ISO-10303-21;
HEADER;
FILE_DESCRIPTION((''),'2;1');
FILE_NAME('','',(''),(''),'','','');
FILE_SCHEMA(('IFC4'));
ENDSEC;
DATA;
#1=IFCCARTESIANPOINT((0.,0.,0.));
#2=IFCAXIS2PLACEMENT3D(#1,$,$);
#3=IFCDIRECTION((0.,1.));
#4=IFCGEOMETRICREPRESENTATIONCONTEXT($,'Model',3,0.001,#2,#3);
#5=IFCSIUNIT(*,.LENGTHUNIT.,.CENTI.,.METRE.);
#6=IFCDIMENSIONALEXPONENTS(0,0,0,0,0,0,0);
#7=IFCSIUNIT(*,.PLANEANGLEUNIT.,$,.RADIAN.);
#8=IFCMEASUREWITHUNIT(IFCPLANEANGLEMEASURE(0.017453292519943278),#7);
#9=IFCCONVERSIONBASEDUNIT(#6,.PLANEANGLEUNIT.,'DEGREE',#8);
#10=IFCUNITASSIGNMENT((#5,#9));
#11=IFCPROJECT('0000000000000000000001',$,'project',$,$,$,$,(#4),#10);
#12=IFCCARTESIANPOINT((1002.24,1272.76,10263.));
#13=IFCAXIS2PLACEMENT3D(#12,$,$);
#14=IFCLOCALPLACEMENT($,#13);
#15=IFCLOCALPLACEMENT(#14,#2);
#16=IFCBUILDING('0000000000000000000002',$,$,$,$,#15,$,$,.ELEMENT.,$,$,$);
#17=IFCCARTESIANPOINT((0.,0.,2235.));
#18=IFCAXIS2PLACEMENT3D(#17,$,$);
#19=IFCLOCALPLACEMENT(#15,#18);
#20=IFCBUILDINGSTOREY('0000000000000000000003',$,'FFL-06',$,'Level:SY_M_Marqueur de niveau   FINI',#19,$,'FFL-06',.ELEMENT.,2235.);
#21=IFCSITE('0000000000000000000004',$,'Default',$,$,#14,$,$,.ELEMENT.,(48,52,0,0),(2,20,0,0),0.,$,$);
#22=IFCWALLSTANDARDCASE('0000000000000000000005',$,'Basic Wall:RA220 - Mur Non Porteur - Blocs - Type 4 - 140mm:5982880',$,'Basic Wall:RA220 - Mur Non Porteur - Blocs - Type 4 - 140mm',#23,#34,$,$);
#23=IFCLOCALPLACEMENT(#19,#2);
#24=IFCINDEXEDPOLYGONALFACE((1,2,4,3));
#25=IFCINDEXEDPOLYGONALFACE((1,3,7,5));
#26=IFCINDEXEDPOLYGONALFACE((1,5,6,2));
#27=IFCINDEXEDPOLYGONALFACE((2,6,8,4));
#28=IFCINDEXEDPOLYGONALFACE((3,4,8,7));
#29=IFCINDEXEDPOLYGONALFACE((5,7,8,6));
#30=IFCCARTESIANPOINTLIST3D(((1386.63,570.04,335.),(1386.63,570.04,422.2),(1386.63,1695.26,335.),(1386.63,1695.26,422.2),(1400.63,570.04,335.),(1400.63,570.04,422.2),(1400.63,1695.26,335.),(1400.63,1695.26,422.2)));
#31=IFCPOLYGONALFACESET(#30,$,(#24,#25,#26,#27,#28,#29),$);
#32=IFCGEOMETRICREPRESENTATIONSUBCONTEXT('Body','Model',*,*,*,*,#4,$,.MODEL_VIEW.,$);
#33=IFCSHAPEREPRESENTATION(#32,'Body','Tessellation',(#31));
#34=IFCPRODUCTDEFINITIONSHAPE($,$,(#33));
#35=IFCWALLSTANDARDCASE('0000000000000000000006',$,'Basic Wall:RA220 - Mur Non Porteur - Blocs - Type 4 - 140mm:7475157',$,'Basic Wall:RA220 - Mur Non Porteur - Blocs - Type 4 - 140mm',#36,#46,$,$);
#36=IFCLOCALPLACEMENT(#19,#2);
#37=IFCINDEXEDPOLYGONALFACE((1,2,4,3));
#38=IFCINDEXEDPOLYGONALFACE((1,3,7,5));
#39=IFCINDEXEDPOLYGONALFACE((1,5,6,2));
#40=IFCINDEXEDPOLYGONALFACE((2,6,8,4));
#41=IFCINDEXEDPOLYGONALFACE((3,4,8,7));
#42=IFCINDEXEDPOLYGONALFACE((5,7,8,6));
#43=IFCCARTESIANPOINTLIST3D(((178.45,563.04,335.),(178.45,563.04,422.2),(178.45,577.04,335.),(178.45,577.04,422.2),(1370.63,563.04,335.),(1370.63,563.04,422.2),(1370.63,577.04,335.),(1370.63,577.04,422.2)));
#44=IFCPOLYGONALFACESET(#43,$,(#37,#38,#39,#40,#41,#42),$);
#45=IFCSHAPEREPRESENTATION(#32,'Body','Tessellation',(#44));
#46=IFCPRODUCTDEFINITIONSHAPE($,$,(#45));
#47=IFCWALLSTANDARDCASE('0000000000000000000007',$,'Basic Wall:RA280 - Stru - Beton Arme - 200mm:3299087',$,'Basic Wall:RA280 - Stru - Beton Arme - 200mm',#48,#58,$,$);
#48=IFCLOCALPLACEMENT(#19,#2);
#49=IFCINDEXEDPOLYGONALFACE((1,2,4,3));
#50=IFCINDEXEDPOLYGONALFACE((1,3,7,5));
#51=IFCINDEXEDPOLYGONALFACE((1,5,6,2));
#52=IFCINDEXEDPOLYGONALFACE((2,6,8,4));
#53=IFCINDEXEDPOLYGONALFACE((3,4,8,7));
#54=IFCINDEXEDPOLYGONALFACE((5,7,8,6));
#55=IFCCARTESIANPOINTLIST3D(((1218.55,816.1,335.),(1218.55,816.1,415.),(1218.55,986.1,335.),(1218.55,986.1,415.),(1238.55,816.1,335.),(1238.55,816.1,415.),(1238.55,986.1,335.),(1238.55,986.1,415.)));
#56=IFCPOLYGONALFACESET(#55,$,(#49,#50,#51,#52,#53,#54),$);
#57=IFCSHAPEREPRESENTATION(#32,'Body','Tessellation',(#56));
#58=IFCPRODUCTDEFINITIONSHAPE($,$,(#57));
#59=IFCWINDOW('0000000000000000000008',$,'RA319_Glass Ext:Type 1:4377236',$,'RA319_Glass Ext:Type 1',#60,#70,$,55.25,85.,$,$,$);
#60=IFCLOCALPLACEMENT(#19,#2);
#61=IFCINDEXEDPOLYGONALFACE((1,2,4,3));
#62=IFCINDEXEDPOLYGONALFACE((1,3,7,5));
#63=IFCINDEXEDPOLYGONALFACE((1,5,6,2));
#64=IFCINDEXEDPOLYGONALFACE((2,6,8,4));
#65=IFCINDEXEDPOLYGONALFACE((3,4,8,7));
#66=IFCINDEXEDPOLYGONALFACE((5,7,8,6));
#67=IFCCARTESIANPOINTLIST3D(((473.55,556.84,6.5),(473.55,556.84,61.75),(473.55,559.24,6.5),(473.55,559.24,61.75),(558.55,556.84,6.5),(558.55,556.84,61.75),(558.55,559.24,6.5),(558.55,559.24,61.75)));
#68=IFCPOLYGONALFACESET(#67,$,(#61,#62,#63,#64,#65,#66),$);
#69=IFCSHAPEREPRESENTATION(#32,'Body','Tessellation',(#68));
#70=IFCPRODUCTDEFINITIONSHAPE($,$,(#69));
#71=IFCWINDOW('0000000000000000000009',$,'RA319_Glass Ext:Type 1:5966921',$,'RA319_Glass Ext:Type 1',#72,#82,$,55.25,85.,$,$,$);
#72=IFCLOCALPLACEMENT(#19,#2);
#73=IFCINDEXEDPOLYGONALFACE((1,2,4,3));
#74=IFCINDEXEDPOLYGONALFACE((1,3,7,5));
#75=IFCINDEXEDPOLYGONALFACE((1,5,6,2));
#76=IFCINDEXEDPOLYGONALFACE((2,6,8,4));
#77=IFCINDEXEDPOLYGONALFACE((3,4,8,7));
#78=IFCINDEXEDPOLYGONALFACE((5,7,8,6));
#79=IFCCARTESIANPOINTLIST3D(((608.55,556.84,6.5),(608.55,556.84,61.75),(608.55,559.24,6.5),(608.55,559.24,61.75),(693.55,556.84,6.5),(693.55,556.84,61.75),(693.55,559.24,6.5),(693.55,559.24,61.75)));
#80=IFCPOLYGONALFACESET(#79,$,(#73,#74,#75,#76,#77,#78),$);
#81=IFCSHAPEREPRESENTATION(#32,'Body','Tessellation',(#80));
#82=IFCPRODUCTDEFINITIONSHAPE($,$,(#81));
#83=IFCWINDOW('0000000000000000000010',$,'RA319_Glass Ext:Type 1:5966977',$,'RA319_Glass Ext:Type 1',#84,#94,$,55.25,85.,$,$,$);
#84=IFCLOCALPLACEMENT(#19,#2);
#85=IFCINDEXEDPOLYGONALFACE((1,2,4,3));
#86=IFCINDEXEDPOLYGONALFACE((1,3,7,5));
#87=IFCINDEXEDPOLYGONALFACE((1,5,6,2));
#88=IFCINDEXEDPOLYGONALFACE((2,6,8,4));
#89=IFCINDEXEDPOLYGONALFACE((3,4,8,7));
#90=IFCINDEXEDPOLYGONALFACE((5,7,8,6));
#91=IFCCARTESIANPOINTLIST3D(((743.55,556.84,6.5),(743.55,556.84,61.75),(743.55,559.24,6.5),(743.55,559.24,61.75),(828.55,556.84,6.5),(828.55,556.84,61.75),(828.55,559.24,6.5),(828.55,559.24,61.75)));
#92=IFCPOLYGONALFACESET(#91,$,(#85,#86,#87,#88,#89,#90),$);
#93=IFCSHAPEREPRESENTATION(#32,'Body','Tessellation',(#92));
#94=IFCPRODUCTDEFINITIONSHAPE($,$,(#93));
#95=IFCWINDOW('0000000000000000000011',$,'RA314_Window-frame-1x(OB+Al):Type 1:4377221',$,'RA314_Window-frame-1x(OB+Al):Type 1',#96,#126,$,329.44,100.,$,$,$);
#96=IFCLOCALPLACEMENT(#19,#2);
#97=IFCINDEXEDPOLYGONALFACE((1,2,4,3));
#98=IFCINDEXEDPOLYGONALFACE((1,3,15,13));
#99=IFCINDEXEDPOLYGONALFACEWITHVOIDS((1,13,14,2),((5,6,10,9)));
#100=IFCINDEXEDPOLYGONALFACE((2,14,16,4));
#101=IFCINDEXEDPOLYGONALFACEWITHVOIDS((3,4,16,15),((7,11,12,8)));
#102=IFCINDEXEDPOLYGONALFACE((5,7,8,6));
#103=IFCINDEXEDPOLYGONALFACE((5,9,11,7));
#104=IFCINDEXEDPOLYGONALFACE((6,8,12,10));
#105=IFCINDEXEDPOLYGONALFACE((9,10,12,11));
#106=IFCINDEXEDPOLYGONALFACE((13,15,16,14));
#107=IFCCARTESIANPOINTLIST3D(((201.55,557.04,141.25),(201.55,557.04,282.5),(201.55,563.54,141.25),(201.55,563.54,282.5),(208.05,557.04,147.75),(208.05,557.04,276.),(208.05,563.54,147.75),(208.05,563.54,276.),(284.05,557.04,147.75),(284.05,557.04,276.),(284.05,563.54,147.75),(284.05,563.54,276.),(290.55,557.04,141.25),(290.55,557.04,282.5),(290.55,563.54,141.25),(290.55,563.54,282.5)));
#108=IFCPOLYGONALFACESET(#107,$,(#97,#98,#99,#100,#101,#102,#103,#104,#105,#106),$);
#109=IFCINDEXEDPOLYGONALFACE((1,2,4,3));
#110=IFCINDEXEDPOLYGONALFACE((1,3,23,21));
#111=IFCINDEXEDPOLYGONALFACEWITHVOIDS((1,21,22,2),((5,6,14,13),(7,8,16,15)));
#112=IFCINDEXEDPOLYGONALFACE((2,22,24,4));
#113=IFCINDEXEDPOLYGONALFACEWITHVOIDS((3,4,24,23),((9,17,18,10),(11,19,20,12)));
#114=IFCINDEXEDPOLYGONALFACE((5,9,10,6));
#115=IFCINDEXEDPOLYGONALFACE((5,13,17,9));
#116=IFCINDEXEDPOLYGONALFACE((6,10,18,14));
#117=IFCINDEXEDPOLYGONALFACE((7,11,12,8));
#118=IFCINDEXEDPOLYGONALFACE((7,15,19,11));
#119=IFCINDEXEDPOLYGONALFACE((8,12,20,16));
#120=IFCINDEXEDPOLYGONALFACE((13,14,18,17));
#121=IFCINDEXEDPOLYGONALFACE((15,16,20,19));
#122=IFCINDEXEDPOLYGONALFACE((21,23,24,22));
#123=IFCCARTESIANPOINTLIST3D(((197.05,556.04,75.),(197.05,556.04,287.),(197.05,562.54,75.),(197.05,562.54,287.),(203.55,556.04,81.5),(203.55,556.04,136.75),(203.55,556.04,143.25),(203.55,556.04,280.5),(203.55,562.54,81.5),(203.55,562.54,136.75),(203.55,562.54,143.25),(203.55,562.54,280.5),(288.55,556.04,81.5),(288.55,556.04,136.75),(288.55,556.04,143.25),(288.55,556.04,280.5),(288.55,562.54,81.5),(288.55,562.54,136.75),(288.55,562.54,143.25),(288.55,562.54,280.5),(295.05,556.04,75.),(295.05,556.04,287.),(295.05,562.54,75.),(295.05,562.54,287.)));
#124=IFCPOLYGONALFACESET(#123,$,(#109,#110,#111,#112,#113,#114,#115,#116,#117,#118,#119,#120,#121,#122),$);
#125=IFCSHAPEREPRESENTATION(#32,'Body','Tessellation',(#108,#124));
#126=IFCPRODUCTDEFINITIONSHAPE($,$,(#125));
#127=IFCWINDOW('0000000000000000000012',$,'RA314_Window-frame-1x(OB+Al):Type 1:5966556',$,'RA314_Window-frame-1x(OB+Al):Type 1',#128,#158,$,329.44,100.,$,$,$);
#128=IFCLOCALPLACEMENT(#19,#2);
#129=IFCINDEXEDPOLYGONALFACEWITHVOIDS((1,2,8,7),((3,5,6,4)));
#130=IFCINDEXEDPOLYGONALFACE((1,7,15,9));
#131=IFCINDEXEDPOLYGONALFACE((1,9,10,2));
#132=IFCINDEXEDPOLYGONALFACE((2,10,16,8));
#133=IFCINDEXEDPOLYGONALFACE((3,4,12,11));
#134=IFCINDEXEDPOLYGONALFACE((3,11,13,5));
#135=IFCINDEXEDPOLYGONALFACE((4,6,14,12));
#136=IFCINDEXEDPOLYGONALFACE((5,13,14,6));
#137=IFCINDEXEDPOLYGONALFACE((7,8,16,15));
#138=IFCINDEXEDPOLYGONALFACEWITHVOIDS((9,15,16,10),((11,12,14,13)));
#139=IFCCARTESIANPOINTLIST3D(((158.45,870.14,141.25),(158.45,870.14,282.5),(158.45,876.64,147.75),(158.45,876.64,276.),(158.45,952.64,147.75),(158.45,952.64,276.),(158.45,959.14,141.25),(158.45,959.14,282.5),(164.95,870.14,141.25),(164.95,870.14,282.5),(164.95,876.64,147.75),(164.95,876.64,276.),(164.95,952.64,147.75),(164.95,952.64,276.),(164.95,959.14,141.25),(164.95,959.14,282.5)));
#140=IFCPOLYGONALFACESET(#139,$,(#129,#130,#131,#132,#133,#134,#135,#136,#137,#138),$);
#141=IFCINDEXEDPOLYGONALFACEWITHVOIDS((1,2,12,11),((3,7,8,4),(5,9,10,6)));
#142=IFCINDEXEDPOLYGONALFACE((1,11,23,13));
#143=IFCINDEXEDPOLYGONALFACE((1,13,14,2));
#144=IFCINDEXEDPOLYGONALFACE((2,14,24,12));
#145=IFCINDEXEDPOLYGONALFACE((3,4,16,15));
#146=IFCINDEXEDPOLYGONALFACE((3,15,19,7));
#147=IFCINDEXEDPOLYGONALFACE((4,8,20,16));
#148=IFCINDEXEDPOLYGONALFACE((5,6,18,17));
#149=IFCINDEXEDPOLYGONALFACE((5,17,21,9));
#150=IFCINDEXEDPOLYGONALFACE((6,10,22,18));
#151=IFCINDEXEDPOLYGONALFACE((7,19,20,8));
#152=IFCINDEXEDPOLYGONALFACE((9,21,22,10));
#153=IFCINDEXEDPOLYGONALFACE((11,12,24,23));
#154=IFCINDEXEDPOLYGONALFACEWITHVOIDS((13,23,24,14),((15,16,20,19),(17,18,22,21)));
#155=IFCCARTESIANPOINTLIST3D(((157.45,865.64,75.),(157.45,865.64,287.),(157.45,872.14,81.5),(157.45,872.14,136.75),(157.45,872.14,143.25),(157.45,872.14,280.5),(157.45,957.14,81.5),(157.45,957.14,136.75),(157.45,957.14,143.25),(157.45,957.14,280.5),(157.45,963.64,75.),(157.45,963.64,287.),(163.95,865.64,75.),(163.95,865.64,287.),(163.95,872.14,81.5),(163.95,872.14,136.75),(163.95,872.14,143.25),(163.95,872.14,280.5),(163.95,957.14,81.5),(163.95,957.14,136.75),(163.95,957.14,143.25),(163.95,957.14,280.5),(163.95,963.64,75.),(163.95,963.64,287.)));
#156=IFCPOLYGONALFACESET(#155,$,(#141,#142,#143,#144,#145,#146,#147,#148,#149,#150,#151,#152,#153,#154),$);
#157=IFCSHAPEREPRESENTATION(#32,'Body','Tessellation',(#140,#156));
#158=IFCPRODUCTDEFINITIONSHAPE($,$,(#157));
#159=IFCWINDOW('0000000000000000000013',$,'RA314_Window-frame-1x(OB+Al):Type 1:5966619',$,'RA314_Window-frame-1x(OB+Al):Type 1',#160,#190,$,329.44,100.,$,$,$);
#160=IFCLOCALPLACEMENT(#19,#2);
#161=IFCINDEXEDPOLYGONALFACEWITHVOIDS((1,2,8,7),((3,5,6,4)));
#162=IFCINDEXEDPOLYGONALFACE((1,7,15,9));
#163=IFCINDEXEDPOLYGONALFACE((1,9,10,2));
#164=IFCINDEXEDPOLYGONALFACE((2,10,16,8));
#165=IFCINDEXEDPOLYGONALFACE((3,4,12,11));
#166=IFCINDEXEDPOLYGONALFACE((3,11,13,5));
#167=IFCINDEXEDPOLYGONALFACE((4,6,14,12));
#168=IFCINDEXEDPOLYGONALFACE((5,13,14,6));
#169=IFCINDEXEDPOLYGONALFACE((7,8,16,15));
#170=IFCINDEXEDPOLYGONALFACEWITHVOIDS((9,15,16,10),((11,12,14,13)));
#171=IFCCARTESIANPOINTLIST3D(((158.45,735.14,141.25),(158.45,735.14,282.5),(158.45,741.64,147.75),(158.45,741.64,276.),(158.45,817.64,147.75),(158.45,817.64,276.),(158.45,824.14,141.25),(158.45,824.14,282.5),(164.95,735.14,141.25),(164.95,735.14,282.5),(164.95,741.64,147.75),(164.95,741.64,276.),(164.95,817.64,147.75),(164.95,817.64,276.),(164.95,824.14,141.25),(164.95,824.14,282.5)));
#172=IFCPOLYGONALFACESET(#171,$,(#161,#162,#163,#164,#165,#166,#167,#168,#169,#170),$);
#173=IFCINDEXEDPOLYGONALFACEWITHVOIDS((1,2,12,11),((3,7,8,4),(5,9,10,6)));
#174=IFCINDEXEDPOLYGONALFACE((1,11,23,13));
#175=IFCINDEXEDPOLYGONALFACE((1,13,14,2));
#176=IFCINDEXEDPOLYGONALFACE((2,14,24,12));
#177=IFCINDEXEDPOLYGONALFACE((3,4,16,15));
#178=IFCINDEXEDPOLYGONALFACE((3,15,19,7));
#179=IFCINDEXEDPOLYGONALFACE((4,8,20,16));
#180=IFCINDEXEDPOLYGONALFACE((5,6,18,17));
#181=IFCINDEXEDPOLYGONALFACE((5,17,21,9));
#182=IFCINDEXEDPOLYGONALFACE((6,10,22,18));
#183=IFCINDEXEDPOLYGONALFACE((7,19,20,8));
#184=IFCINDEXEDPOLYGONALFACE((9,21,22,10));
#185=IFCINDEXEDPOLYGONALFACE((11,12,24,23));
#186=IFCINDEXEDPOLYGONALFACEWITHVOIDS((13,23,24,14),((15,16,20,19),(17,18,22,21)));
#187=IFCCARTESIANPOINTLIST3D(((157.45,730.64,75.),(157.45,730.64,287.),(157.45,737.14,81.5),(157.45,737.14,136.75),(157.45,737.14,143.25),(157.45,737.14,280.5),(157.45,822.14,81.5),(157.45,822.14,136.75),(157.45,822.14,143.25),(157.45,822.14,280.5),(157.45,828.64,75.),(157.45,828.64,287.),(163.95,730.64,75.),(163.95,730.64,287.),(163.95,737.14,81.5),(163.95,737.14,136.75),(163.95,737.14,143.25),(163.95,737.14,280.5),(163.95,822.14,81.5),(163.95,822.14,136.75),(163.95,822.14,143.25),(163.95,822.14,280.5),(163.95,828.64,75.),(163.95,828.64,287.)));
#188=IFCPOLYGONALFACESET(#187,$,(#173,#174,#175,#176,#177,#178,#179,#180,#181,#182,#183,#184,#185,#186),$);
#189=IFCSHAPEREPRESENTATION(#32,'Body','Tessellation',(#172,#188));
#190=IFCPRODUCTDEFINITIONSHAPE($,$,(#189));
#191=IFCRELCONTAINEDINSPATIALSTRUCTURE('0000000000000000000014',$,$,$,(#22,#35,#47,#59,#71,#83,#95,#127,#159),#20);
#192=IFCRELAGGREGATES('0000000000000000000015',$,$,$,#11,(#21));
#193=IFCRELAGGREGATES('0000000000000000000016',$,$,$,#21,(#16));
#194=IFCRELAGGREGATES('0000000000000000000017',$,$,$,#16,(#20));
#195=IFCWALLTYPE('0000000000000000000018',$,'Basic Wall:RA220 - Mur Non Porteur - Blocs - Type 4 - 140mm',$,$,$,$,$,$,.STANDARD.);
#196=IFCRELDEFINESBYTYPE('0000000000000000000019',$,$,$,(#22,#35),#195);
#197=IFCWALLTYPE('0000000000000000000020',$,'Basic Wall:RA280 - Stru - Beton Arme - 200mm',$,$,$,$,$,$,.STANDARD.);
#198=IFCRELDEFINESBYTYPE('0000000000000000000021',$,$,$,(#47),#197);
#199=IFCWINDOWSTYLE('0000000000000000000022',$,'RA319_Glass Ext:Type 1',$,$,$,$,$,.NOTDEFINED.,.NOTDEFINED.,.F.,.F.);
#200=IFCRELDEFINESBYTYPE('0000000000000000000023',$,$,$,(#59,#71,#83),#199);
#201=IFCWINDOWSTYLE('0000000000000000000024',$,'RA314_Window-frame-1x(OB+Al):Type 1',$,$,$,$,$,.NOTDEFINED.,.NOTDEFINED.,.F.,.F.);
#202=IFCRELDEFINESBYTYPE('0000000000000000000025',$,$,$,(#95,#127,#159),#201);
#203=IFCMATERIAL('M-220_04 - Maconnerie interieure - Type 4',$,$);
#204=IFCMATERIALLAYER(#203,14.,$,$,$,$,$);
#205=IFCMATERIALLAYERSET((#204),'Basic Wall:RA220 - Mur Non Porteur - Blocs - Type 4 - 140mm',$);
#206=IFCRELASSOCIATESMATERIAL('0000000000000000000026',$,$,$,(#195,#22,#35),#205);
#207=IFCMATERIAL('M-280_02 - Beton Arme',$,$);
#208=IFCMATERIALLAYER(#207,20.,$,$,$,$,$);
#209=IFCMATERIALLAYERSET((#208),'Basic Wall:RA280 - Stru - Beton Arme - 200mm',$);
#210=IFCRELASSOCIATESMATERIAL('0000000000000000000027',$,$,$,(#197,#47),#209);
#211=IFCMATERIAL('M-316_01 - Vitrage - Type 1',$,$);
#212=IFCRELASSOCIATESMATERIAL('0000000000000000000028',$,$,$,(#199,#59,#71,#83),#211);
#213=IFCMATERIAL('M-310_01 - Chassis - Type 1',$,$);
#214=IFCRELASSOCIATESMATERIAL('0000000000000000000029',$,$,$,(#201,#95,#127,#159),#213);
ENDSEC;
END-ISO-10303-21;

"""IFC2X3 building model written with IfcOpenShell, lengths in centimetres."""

from ifc_helpers import new_model, entity, si_unit, converted_unit, direction, frame, frame_2d, origin, place, context, subcontext, project, spatial, polyline, rectangle, outline, extrude, clip, bounded_halfspace, source, transform, mapped, material, layer, layer_set, layer_usage, type_object, type_shapes, element, save


model = new_model("IFC2X3")

# Units and contexts
model_context = context("Model", 3, precision=0.001, world=origin(), true_north=direction((0.0, 1.0)))
body_context = subcontext(model_context, "Body", "Model", "MODEL_VIEW")
ifc_project = project(units=[si_unit("LENGTHUNIT", "METRE", prefix="CENTI"), converted_unit("PLANEANGLEUNIT", "DEGREE", entity("IfcPlaneAngleMeasure", 0.017453292519943278), si_unit("PLANEANGLEUNIT", "RADIAN"), dimensions=[0, 0, 0, 0, 0, 0, 0])], contexts=[model_context])

# Site, building, storey
site_placement = place(None, frame((1002.24, 1272.76, 10263.0)))
site = spatial("IfcSite", under=ifc_project, at=site_placement, Name="Default", CompositionType="ELEMENT", RefLatitude=(48, 52, 0, 0), RefLongitude=(2, 20, 0, 0), RefElevation=0.0)
building_placement = place(site_placement, origin())
building = spatial("IfcBuilding", under=site, at=building_placement, CompositionType="ELEMENT")
storey_placement = place(building_placement, frame((0.0, 0.0, 2235.0)))
storey = spatial("IfcBuildingStorey", under=building, at=storey_placement, Name="FFL-06", ObjectType="Level:SY_M_Marqueur de niveau   FINI", LongName="FFL-06", CompositionType="ELEMENT", Elevation=2235.0)

# Walls
ifc_material_1 = material(Name="M-280_02 - Beton Arme")
ifc_material_2 = material(Name="M-220_04 - Maconnerie interieure - Type 4")
ifc_layer_1 = layer(ifc_material_2, 14.0)
ifc_layer_set_1 = layer_set([ifc_layer_1], Name="Basic Wall:RA220 - Mur Non Porteur - Blocs - Type 4 - 140mm")
ifc_layer_usage_1 = layer_usage(ifc_layer_set_1, "AXIS2", "POSITIVE", -7.0)
wall_type_1 = type_object("IfcWallType", Name="Basic Wall:RA220 - Mur Non Porteur - Blocs - Type 4 - 140mm", PredefinedType="STANDARD", material=ifc_layer_set_1)
wall_1_placement = place(storey_placement, frame((1393.63, 570.04, 335.0), z_axis=(0.0, 0.0, 1.0), x_axis=(0.0, 1.0, 0.0)))
element("IfcWallStandardCase", 1, at=wall_1_placement, inside=storey, type_object=wall_type_1, material=ifc_layer_usage_1, Name="Basic Wall:RA220 - Mur Non Porteur - Blocs - Type 4 - 140mm:5982880", ObjectType="Basic Wall:RA220 - Mur Non Porteur - Blocs - Type 4 - 140mm", context=body_context, shape_type="SweptSolid", body=[
    extrude(rectangle(XDim=1125.22, YDim=14.0, at=frame_2d((562.61, 0.0), x_axis=(-1.0, 0.0))), origin(), (0.0, 0.0, 1.0), 87.2),
])
ifc_layer_usage_2 = layer_usage(ifc_layer_set_1, "AXIS2", "NEGATIVE", 7.0)
wall_2_placement = place(storey_placement, frame((1370.63, 570.04, 335.0), z_axis=(0.0, 0.0, 1.0), x_axis=(-1.0, 0.0, 0.0)))
element("IfcWallStandardCase", 2, at=wall_2_placement, inside=storey, type_object=wall_type_1, material=ifc_layer_usage_2, Name="Basic Wall:RA220 - Mur Non Porteur - Blocs - Type 4 - 140mm:7475157", ObjectType="Basic Wall:RA220 - Mur Non Porteur - Blocs - Type 4 - 140mm", context=body_context, shape_type="SweptSolid", body=[
    extrude(rectangle(XDim=1192.19, YDim=14.0, at=frame_2d((596.09, 0.0), x_axis=(-1.0, 0.0))), origin(), (0.0, 0.0, 1.0), 87.2),
])
ifc_layer_2 = layer(ifc_material_1, 20.0)
ifc_layer_set_2 = layer_set([ifc_layer_2], Name="Basic Wall:RA280 - Stru - Beton Arme - 200mm")
ifc_layer_usage_3 = layer_usage(ifc_layer_set_2, "AXIS2", "NEGATIVE", 10.0)
wall_type_2 = type_object("IfcWallType", Name="Basic Wall:RA280 - Stru - Beton Arme - 200mm", PredefinedType="STANDARD", material=ifc_layer_set_2)
wall_3_placement = place(storey_placement, frame((1228.55, 816.1, 335.0), z_axis=(0.0, 0.0, 1.0), x_axis=(0.0, 1.0, 0.0)))
element("IfcWallStandardCase", 3, at=wall_3_placement, inside=storey, type_object=wall_type_2, material=ifc_layer_usage_3, Name="Basic Wall:RA280 - Stru - Beton Arme - 200mm:3299087", ObjectType="Basic Wall:RA280 - Stru - Beton Arme - 200mm", context=body_context, shape_type="Clipping", body=[
    clip(clip(extrude(rectangle(XDim=170.0, YDim=20.0, at=frame_2d((85.0, 0.0), x_axis=(-1.0, 0.0))), origin(), (0.0, 0.0, 1.0), 80.0), bounded_halfspace(frame((0.0, -10.0, 80.0), z_axis=(0.0, 0.0, -1.0), x_axis=(-1.0, 0.0, 0.0)), True, frame((0.0, -10.0, 80.0)), polyline([(0.0, 0.0), (170.0, 0.0), (170.0, 20.0), (0.0, 20.0), (0.0, 0.0)]))), bounded_halfspace(frame((170.0, -10.0, 0.0), z_axis=(0.0, 0.0, 1.0), x_axis=(0.0, 1.0, 0.0)), True, frame((170.0, -10.0, 0.0), z_axis=(0.0, 0.0, 1.0), x_axis=(0.0, 1.0, 0.0)), polyline([(0.0, 0.0), (20.0, 0.0), (20.0, 170.0), (0.0, 170.0), (0.0, 0.0)]))),
])

# Windows
ifc_material_3 = material(Name="M-316_01 - Vitrage - Type 1")
window_style_1 = type_object("IfcWindowStyle", Name="RA319_Glass Ext:Type 1", ConstructionType="NOTDEFINED", OperationType="NOTDEFINED", ParameterTakesPrecedence=False, Sizeable=False, material=ifc_material_3)
shared_shape_1 = source(origin(), body_context, "Body", "SweptSolid", [
    extrude(rectangle(XDim=85.0, YDim=55.25, at=frame_2d((0.0, 0.0), x_axis=(1.0, 0.0))), frame((0.0, 0.0, 0.0), z_axis=(0.0, 0.0, 1.0), x_axis=(-1.0, 0.0, 0.0)), (0.0, 0.0, 1.0), 2.4),
])
type_shapes(window_style_1, [shared_shape_1])
for number, where, z_axis, x_axis, name in (
    (4, (516.05, 556.84, 34.12), (0.0, 1.0, 0.0), (-1.0, 0.0, 0.0), "RA319_Glass Ext:Type 1:4377236"),
    (5, (651.05, 556.84, 34.12), (0.0, 1.0, 0.0), (-1.0, 0.0, 0.0), "RA319_Glass Ext:Type 1:5966921"),
    (6, (786.05, 556.84, 34.12), (0.0, 1.0, 0.0), (-1.0, 0.0, 0.0), "RA319_Glass Ext:Type 1:5966977"),
):
    element("IfcWindow", number, at=place(storey_placement, frame(where, z_axis=z_axis, x_axis=x_axis)), inside=storey, type_object=window_style_1, material=ifc_material_3, Name=name, ObjectType="RA319_Glass Ext:Type 1", OverallHeight=55.25, OverallWidth=85.0, context=body_context, shape_type="MappedRepresentation", body=[
        mapped(shared_shape_1, transform((0.0, 0.0, 0.0), scale=1.0)),
    ])
ifc_material_4 = material(Name="M-310_01 - Chassis - Type 1")
window_style_2 = type_object("IfcWindowStyle", Name="RA314_Window-frame-1x(OB+Al):Type 1", ConstructionType="NOTDEFINED", OperationType="NOTDEFINED", ParameterTakesPrecedence=False, Sizeable=False, material=ifc_material_4)
shared_shape_2 = source(origin(), body_context, "Body", "SweptSolid", [
    extrude(outline(polyline([(-70.62, -44.5), (70.62, -44.5), (70.62, 44.5), (-70.62, 44.5), (-70.62, -44.5)]), holes=[polyline([(-64.12, -38.0), (-64.12, 38.0), (64.12, 38.0), (64.12, -38.0), (-64.12, -38.0)])]), frame((0.0, -7.5, 136.87), z_axis=(0.0, 1.0, 0.0), x_axis=(0.0, 0.0, -1.0)), (0.0, 0.0, 1.0), 6.5),
    extrude(outline(polyline([(-106.0, -49.0), (106.0, -49.0), (106.0, 49.0), (-106.0, 49.0), (-106.0, -49.0)]), holes=[polyline([(-99.5, -42.5), (-99.5, 42.5), (37.75, 42.5), (37.75, -42.5), (-99.5, -42.5)]), polyline([(44.25, -42.5), (44.25, 42.5), (99.5, 42.5), (99.5, -42.5), (44.25, -42.5)])]), frame((0.0, -6.5, 106.0), z_axis=(0.0, 1.0, 0.0), x_axis=(0.0, 0.0, -1.0)), (0.0, 0.0, 1.0), 6.5),
])
type_shapes(window_style_2, [shared_shape_2])
for number, where, z_axis, x_axis, name in (
    (7, (246.05, 556.04, 75.0), (0.0, 0.0, 1.0), (-1.0, 0.0, 0.0), "RA314_Window-frame-1x(OB+Al):Type 1:4377221"),
    (8, (157.45, 914.64, 75.0), (0.0, 0.0, 1.0), (0.0, 1.0, 0.0), "RA314_Window-frame-1x(OB+Al):Type 1:5966556"),
    (9, (157.45, 779.64, 75.0), (0.0, 0.0, 1.0), (0.0, 1.0, 0.0), "RA314_Window-frame-1x(OB+Al):Type 1:5966619"),
):
    element("IfcWindow", number, at=place(storey_placement, frame(where, z_axis=z_axis, x_axis=x_axis)), inside=storey, type_object=window_style_2, material=ifc_material_4, Name=name, ObjectType="RA314_Window-frame-1x(OB+Al):Type 1", OverallHeight=329.44, OverallWidth=100.0, context=body_context, shape_type="MappedRepresentation", body=[
        mapped(shared_shape_2, transform((0.0, 0.0, 0.0), scale=1.0)),
    ])

save(model, "model.ifc")
